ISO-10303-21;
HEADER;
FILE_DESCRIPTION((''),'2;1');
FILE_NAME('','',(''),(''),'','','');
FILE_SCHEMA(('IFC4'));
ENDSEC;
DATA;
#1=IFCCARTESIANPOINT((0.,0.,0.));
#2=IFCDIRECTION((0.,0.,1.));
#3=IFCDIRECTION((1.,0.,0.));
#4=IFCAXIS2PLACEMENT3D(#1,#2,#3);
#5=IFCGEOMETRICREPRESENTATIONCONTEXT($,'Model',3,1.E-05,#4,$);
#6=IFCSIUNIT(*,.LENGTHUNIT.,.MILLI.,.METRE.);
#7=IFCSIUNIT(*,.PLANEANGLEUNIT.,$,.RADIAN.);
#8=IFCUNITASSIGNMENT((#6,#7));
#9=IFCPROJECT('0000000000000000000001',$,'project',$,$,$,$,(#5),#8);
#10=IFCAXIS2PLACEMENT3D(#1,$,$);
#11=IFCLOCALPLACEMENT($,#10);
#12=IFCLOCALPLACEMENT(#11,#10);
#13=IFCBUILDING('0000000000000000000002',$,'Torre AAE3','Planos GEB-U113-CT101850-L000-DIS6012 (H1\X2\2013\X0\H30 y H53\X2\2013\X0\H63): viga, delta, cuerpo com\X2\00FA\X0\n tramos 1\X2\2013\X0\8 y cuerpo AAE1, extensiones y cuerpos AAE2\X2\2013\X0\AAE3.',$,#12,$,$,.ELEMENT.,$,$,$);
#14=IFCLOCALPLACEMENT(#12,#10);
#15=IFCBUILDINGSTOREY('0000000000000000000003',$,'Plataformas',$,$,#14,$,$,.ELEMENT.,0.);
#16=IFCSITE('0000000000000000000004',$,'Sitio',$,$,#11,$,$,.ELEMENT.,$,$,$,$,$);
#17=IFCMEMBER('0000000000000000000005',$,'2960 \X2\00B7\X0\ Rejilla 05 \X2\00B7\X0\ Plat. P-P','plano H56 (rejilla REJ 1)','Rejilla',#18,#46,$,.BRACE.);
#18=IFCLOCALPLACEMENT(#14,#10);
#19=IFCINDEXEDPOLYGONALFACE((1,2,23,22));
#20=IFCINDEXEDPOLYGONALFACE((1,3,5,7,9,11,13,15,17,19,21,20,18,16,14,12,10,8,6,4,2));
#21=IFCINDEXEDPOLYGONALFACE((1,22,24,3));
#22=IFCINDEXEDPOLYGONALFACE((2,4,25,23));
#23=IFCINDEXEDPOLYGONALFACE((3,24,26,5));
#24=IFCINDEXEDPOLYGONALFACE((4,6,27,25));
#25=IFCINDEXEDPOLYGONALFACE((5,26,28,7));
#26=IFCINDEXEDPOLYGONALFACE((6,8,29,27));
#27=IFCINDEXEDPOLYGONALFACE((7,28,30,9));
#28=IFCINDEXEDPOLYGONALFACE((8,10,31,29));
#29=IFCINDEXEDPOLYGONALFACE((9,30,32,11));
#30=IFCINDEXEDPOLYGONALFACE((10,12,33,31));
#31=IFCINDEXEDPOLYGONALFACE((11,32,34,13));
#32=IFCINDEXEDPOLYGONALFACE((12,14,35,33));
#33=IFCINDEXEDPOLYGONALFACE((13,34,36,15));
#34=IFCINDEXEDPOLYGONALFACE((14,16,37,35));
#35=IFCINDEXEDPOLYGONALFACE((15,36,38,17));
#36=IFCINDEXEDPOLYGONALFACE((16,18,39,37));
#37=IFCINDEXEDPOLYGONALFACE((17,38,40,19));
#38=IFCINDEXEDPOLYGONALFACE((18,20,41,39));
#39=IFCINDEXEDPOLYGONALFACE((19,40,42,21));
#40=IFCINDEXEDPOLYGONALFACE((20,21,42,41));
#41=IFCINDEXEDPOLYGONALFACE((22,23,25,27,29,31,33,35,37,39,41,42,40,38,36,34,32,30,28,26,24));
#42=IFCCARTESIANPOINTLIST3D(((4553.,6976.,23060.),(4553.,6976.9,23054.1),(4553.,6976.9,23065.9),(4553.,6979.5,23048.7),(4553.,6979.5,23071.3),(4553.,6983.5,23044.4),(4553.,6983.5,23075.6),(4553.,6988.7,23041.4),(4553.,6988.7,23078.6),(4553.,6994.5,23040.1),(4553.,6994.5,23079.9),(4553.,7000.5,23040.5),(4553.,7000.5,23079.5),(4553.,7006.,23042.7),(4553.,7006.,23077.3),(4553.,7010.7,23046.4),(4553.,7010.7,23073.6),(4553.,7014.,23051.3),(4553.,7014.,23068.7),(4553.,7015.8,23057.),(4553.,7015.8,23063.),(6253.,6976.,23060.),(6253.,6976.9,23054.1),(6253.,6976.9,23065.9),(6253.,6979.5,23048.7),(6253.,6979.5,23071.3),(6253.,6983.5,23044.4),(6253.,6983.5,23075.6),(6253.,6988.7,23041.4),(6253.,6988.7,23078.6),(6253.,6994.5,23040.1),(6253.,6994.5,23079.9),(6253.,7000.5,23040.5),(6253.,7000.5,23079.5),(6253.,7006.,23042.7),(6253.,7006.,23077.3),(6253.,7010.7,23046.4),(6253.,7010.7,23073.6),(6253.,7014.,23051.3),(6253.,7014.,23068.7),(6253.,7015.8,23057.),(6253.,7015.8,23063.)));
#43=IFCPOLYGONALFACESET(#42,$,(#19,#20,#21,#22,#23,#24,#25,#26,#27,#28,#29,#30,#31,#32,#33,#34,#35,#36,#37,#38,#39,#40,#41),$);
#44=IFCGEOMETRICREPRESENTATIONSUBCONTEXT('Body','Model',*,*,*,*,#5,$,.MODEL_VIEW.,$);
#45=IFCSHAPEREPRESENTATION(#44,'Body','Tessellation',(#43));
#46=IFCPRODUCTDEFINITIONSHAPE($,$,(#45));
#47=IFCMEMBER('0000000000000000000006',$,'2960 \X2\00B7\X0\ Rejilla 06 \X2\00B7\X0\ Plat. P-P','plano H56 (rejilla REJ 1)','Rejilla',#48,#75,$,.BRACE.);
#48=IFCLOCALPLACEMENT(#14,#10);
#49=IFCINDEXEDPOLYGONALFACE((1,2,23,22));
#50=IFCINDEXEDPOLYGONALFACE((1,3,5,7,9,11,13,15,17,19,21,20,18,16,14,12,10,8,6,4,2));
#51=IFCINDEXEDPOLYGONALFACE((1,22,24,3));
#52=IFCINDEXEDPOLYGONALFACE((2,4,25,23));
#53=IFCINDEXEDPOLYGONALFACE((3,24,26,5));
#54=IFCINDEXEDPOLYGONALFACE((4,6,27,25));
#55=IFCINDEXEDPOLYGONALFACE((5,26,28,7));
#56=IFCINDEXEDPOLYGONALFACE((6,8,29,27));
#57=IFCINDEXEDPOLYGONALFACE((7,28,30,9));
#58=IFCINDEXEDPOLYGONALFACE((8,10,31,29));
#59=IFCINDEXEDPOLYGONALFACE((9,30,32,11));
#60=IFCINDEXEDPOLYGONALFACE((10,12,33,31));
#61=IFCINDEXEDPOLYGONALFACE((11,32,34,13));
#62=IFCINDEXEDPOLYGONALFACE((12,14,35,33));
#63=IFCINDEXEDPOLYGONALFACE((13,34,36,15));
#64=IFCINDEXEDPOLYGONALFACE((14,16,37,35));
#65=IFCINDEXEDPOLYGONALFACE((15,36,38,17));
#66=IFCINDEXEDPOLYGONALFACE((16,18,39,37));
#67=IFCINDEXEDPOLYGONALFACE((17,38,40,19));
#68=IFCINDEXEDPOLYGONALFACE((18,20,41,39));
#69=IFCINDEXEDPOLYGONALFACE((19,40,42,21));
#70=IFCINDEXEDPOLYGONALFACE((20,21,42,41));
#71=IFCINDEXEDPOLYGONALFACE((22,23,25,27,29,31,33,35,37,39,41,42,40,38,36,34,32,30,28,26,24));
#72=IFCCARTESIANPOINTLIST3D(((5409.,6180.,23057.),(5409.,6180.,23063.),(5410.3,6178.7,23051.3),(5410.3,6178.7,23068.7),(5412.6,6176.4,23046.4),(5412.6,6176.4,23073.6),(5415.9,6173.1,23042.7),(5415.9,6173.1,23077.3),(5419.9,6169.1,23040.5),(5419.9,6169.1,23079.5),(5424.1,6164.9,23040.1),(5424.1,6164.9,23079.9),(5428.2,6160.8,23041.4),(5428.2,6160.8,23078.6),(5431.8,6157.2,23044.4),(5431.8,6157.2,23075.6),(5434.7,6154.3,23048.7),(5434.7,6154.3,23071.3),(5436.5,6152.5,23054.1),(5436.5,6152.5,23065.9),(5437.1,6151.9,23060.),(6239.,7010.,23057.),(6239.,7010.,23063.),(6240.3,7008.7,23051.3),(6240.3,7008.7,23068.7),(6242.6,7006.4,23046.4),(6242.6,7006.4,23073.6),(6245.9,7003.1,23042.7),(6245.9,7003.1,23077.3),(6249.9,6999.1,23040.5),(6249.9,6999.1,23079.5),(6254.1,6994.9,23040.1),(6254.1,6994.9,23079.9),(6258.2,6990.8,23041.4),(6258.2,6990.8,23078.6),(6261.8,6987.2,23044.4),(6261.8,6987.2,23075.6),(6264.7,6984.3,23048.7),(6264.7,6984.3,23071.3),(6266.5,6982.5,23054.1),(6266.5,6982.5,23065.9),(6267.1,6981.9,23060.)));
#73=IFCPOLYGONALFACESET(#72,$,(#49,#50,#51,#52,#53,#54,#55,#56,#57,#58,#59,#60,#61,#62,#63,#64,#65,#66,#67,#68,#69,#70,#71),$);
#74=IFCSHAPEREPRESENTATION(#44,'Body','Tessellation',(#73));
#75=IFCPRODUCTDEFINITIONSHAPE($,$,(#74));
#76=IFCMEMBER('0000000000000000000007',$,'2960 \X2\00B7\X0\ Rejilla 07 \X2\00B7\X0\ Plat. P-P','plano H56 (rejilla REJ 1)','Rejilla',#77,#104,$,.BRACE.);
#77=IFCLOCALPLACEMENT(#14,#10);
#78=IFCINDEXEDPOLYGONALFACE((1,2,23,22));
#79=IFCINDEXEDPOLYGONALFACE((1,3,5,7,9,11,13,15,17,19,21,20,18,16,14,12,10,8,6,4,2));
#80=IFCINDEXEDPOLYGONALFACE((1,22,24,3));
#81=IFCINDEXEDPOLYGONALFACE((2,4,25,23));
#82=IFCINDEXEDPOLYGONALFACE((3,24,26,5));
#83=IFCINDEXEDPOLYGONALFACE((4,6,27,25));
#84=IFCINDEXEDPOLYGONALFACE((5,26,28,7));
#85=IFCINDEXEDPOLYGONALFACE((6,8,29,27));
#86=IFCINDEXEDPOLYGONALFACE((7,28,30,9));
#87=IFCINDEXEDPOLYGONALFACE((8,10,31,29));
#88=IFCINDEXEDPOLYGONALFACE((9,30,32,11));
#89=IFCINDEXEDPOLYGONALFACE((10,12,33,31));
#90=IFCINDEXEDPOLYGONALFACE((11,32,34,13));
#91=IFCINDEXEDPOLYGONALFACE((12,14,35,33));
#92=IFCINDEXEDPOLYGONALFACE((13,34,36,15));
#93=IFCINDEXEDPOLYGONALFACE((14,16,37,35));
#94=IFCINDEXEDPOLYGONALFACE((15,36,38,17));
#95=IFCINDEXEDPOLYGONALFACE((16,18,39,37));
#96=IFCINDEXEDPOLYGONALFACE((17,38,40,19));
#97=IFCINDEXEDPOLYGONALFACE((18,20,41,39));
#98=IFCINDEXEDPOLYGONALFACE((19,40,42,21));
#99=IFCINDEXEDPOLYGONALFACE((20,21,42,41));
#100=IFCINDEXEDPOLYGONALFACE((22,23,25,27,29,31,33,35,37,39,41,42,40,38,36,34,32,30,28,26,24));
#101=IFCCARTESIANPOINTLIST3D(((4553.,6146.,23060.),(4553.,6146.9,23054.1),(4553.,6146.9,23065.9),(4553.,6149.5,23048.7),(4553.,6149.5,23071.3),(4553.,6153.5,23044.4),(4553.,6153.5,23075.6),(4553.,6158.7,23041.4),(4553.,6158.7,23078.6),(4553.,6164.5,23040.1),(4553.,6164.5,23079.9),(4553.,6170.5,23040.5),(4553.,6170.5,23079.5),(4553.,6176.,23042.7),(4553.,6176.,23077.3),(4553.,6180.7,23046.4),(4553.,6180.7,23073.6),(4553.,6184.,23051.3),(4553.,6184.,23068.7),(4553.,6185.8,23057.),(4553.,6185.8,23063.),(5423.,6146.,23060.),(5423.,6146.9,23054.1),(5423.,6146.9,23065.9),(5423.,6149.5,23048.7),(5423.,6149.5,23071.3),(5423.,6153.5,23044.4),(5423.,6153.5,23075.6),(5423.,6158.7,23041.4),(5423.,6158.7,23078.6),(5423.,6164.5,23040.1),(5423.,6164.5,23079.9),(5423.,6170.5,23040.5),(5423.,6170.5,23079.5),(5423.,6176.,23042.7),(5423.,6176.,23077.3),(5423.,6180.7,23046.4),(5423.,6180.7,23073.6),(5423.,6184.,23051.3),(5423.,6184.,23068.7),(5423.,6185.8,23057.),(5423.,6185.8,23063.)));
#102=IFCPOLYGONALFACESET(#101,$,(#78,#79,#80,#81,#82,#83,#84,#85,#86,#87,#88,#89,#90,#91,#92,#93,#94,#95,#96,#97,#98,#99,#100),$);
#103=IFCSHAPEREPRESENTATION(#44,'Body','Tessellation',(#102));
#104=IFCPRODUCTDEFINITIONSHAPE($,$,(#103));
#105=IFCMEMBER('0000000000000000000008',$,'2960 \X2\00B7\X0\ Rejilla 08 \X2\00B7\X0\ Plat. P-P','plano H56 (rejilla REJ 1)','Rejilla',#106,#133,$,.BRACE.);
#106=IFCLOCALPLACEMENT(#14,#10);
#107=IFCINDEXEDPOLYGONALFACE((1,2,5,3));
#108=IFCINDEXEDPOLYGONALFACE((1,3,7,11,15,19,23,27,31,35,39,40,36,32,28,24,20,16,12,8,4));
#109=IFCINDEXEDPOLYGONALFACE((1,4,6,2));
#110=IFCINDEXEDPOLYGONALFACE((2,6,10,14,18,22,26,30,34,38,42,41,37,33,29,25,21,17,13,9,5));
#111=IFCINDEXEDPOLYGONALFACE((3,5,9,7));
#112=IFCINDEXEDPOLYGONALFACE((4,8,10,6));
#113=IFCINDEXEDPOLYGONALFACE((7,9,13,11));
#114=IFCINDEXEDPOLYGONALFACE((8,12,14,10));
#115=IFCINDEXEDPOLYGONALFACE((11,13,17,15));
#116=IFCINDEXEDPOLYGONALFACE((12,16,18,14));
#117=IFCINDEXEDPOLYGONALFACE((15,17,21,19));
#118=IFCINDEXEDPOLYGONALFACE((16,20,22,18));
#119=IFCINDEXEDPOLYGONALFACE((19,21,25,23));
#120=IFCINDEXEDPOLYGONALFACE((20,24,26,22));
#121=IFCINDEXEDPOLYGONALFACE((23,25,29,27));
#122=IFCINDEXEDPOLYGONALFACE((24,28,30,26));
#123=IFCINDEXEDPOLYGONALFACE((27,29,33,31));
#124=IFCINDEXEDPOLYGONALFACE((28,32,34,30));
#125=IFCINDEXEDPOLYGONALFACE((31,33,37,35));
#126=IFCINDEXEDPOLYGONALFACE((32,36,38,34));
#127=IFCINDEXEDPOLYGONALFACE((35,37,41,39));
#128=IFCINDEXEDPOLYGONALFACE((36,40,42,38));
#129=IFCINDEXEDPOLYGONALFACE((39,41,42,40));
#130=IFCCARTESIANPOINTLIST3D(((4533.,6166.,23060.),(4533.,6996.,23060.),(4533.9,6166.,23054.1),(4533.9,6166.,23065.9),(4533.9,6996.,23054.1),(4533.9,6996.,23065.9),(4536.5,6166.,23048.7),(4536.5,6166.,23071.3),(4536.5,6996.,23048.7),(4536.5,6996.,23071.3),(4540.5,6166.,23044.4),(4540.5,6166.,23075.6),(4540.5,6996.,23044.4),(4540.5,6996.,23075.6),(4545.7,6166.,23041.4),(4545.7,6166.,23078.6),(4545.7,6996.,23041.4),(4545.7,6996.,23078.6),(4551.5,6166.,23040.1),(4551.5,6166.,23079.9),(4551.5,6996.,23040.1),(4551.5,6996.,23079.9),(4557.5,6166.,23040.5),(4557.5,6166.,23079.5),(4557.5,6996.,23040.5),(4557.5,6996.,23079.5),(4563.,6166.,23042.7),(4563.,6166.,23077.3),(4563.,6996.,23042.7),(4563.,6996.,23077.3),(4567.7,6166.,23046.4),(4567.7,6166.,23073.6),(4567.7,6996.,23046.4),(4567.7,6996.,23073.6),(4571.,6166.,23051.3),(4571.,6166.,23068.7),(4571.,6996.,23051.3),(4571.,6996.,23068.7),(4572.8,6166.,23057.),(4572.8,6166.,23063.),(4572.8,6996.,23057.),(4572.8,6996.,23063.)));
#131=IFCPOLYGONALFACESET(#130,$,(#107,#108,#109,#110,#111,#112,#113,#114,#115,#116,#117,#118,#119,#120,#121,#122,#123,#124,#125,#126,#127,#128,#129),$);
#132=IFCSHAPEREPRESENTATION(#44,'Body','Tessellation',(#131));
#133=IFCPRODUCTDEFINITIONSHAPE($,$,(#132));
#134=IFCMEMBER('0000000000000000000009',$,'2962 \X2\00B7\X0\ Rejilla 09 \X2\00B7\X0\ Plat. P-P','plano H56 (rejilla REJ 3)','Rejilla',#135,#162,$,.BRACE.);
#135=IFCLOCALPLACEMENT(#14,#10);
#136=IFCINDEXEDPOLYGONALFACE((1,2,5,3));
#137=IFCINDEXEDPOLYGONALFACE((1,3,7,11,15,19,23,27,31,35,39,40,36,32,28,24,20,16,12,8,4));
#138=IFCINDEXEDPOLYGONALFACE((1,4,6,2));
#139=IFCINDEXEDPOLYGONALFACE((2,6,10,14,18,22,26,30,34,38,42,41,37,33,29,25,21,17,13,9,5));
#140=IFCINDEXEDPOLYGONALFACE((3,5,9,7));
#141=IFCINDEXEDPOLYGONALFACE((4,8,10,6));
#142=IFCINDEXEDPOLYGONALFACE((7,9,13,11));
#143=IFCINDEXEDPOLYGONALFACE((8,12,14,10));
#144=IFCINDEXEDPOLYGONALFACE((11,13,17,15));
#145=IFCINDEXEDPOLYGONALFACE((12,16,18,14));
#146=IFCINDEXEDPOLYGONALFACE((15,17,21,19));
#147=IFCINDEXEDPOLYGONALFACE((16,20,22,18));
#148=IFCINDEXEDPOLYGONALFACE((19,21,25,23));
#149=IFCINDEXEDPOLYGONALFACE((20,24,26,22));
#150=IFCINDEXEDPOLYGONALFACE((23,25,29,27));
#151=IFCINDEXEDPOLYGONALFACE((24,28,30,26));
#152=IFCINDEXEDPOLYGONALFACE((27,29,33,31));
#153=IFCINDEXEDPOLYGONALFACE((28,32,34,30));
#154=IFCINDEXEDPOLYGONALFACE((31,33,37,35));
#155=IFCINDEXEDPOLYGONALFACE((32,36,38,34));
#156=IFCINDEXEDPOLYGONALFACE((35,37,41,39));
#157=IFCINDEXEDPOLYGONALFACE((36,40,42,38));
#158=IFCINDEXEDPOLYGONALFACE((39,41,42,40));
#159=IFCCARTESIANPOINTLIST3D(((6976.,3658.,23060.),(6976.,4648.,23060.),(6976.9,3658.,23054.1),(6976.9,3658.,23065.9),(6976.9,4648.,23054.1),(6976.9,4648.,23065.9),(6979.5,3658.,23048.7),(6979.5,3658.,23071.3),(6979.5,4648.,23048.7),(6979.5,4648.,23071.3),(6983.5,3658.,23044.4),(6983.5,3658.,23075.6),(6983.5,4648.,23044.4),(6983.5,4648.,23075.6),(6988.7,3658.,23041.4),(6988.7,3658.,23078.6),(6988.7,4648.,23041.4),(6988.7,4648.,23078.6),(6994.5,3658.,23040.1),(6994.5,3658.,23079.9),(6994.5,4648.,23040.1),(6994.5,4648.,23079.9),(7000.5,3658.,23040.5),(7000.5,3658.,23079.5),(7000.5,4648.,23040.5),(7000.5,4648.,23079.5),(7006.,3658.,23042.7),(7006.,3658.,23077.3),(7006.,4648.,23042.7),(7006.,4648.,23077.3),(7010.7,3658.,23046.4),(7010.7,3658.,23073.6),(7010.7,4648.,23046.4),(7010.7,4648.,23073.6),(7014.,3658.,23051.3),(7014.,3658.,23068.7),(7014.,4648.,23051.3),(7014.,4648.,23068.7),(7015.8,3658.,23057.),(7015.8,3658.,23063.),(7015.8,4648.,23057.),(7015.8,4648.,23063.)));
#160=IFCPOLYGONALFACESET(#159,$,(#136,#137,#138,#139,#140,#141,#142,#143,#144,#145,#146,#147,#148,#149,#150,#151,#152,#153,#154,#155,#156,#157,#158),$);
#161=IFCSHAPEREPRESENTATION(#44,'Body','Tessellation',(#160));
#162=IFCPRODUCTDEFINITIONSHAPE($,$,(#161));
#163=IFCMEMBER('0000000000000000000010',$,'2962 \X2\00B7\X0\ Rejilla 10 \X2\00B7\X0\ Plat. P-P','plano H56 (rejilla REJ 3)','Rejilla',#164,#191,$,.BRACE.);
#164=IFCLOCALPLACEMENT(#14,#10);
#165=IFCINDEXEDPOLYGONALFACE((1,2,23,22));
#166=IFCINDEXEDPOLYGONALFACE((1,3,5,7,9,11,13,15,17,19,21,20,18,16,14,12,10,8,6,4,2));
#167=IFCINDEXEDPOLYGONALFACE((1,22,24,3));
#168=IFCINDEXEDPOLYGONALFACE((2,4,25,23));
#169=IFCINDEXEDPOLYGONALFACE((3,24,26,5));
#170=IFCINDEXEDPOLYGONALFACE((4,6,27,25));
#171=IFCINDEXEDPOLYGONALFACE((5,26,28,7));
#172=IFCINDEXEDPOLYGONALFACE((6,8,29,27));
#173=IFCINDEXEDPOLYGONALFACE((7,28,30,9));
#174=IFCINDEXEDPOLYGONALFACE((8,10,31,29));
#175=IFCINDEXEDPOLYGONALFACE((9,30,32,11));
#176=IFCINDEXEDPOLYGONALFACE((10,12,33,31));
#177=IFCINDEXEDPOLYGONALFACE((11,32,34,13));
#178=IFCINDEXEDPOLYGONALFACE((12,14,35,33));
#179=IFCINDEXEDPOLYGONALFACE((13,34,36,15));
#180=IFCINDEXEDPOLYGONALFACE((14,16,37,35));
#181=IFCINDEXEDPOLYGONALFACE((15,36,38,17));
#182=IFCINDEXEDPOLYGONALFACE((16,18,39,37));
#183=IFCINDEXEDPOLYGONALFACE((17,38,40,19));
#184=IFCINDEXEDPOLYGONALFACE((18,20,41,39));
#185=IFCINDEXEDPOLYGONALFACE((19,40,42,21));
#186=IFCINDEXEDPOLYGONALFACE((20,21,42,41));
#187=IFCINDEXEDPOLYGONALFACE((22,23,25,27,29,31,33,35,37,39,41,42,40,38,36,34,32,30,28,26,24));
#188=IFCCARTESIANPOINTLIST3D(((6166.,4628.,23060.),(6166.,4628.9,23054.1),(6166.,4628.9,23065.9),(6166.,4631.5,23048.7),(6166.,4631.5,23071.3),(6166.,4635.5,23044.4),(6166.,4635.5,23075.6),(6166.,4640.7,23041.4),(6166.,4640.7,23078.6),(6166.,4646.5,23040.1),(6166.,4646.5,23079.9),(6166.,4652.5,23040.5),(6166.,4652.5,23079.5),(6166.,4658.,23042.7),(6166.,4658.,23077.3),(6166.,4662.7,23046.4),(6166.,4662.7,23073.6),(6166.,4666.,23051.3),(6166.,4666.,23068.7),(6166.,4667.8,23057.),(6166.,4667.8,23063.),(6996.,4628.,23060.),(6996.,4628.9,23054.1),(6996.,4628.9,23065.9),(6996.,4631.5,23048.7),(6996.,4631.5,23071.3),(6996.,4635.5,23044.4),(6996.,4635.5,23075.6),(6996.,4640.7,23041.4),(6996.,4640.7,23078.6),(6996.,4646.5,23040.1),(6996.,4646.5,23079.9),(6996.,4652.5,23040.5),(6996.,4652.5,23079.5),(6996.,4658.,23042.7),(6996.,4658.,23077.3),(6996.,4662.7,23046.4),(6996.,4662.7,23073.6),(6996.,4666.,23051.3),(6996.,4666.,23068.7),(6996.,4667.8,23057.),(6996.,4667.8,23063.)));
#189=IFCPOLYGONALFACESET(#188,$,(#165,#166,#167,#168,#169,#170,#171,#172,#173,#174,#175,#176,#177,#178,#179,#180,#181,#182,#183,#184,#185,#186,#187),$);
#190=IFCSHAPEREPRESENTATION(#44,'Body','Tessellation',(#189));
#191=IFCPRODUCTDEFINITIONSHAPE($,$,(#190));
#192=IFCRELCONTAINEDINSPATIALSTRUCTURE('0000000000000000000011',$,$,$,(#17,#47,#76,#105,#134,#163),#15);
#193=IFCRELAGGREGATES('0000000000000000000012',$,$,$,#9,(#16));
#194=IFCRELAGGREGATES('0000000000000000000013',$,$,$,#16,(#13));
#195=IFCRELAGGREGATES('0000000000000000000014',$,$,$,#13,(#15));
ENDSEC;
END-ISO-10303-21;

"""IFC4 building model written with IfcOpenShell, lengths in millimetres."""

from ifc_helpers import new_model, si_unit, frame, origin, origin_with_axes, place, context, subcontext, project, spatial, circle, extrude, element, save


model = new_model("IFC4")

# Units and contexts
model_context = context("Model", 3, precision=1e-05, world=origin_with_axes())
body_context = subcontext(model_context, "Body", "Model", "MODEL_VIEW")
ifc_project = project(units=[si_unit("LENGTHUNIT", "METRE", prefix="MILLI"), si_unit("PLANEANGLEUNIT", "RADIAN")], contexts=[model_context])

# Site, building, storey
site_placement = place(None, origin())
site = spatial("IfcSite", under=ifc_project, at=site_placement, Name="Sitio", CompositionType="ELEMENT")
building_placement = place(site_placement, origin())
building = spatial("IfcBuilding", under=site, at=building_placement, Name="Torre AAE3", Description="Planos GEB-U113-CT101850-L000-DIS6012 (H1–H30 y H53–H63): viga, delta, cuerpo común tramos 1–8 y cuerpo AAE1, extensiones y cuerpos AAE2–AAE3.", CompositionType="ELEMENT")
storey_placement = place(building_placement, origin())
storey = spatial("IfcBuildingStorey", under=building, at=storey_placement, Name="Plataformas", CompositionType="ELEMENT", Elevation=0.0)

# Members
member_1_placement = place(storey_placement, frame((4553.0, 6996.0, 23060.0), z_axis=(1.0, 0.0, 0.0), x_axis=(0.0, -1.0, 0.0)))
element("IfcMember", 1, at=member_1_placement, inside=storey, Name="2960 · Rejilla 05 · Plat. P-P", Description="plano H56 (rejilla REJ 1)", ObjectType="Rejilla", PredefinedType="BRACE", context=body_context, shape_type="SweptSolid", body=[
    extrude(circle(Radius=20.0), None, (0.0, 0.0, 1.0), 1700.0),
])
member_2_placement = place(storey_placement, frame((6253.0, 6996.0, 23060.0), z_axis=(-0.707107, -0.707107, 0.0), x_axis=(0.707107, -0.707107, 0.0)))
element("IfcMember", 2, at=member_2_placement, inside=storey, Name="2960 · Rejilla 06 · Plat. P-P", Description="plano H56 (rejilla REJ 1)", ObjectType="Rejilla", PredefinedType="BRACE", context=body_context, shape_type="SweptSolid", body=[
    extrude(circle(Radius=20.0), None, (0.0, 0.0, 1.0), 1173.8),
])
member_3_placement = place(storey_placement, frame((5423.0, 6166.0, 23060.0), z_axis=(-1.0, 0.0, 0.0), x_axis=(0.0, -1.0, 0.0)))
element("IfcMember", 3, at=member_3_placement, inside=storey, Name="2960 · Rejilla 07 · Plat. P-P", Description="plano H56 (rejilla REJ 1)", ObjectType="Rejilla", PredefinedType="BRACE", context=body_context, shape_type="SweptSolid", body=[
    extrude(circle(Radius=20.0), None, (0.0, 0.0, 1.0), 870.0),
])
member_4_placement = place(storey_placement, frame((4553.0, 6166.0, 23060.0), z_axis=(0.0, 1.0, 0.0), x_axis=(-1.0, 0.0, 0.0)))
element("IfcMember", 4, at=member_4_placement, inside=storey, Name="2960 · Rejilla 08 · Plat. P-P", Description="plano H56 (rejilla REJ 1)", ObjectType="Rejilla", PredefinedType="BRACE", context=body_context, shape_type="SweptSolid", body=[
    extrude(circle(Radius=20.0), None, (0.0, 0.0, 1.0), 830.0),
])
member_5_placement = place(storey_placement, frame((6996.0, 3658.0, 23060.0), z_axis=(0.0, 1.0, 0.0), x_axis=(-1.0, 0.0, 0.0)))
element("IfcMember", 5, at=member_5_placement, inside=storey, Name="2962 · Rejilla 09 · Plat. P-P", Description="plano H56 (rejilla REJ 3)", ObjectType="Rejilla", PredefinedType="BRACE", context=body_context, shape_type="SweptSolid", body=[
    extrude(circle(Radius=20.0), None, (0.0, 0.0, 1.0), 990.0),
])
member_6_placement = place(storey_placement, frame((6996.0, 4648.0, 23060.0), z_axis=(-1.0, 0.0, 0.0), x_axis=(0.0, -1.0, 0.0)))
element("IfcMember", 6, at=member_6_placement, inside=storey, Name="2962 · Rejilla 10 · Plat. P-P", Description="plano H56 (rejilla REJ 3)", ObjectType="Rejilla", PredefinedType="BRACE", context=body_context, shape_type="SweptSolid", body=[
    extrude(circle(Radius=20.0), None, (0.0, 0.0, 1.0), 830.0),
])

save(model, "model.ifc")
